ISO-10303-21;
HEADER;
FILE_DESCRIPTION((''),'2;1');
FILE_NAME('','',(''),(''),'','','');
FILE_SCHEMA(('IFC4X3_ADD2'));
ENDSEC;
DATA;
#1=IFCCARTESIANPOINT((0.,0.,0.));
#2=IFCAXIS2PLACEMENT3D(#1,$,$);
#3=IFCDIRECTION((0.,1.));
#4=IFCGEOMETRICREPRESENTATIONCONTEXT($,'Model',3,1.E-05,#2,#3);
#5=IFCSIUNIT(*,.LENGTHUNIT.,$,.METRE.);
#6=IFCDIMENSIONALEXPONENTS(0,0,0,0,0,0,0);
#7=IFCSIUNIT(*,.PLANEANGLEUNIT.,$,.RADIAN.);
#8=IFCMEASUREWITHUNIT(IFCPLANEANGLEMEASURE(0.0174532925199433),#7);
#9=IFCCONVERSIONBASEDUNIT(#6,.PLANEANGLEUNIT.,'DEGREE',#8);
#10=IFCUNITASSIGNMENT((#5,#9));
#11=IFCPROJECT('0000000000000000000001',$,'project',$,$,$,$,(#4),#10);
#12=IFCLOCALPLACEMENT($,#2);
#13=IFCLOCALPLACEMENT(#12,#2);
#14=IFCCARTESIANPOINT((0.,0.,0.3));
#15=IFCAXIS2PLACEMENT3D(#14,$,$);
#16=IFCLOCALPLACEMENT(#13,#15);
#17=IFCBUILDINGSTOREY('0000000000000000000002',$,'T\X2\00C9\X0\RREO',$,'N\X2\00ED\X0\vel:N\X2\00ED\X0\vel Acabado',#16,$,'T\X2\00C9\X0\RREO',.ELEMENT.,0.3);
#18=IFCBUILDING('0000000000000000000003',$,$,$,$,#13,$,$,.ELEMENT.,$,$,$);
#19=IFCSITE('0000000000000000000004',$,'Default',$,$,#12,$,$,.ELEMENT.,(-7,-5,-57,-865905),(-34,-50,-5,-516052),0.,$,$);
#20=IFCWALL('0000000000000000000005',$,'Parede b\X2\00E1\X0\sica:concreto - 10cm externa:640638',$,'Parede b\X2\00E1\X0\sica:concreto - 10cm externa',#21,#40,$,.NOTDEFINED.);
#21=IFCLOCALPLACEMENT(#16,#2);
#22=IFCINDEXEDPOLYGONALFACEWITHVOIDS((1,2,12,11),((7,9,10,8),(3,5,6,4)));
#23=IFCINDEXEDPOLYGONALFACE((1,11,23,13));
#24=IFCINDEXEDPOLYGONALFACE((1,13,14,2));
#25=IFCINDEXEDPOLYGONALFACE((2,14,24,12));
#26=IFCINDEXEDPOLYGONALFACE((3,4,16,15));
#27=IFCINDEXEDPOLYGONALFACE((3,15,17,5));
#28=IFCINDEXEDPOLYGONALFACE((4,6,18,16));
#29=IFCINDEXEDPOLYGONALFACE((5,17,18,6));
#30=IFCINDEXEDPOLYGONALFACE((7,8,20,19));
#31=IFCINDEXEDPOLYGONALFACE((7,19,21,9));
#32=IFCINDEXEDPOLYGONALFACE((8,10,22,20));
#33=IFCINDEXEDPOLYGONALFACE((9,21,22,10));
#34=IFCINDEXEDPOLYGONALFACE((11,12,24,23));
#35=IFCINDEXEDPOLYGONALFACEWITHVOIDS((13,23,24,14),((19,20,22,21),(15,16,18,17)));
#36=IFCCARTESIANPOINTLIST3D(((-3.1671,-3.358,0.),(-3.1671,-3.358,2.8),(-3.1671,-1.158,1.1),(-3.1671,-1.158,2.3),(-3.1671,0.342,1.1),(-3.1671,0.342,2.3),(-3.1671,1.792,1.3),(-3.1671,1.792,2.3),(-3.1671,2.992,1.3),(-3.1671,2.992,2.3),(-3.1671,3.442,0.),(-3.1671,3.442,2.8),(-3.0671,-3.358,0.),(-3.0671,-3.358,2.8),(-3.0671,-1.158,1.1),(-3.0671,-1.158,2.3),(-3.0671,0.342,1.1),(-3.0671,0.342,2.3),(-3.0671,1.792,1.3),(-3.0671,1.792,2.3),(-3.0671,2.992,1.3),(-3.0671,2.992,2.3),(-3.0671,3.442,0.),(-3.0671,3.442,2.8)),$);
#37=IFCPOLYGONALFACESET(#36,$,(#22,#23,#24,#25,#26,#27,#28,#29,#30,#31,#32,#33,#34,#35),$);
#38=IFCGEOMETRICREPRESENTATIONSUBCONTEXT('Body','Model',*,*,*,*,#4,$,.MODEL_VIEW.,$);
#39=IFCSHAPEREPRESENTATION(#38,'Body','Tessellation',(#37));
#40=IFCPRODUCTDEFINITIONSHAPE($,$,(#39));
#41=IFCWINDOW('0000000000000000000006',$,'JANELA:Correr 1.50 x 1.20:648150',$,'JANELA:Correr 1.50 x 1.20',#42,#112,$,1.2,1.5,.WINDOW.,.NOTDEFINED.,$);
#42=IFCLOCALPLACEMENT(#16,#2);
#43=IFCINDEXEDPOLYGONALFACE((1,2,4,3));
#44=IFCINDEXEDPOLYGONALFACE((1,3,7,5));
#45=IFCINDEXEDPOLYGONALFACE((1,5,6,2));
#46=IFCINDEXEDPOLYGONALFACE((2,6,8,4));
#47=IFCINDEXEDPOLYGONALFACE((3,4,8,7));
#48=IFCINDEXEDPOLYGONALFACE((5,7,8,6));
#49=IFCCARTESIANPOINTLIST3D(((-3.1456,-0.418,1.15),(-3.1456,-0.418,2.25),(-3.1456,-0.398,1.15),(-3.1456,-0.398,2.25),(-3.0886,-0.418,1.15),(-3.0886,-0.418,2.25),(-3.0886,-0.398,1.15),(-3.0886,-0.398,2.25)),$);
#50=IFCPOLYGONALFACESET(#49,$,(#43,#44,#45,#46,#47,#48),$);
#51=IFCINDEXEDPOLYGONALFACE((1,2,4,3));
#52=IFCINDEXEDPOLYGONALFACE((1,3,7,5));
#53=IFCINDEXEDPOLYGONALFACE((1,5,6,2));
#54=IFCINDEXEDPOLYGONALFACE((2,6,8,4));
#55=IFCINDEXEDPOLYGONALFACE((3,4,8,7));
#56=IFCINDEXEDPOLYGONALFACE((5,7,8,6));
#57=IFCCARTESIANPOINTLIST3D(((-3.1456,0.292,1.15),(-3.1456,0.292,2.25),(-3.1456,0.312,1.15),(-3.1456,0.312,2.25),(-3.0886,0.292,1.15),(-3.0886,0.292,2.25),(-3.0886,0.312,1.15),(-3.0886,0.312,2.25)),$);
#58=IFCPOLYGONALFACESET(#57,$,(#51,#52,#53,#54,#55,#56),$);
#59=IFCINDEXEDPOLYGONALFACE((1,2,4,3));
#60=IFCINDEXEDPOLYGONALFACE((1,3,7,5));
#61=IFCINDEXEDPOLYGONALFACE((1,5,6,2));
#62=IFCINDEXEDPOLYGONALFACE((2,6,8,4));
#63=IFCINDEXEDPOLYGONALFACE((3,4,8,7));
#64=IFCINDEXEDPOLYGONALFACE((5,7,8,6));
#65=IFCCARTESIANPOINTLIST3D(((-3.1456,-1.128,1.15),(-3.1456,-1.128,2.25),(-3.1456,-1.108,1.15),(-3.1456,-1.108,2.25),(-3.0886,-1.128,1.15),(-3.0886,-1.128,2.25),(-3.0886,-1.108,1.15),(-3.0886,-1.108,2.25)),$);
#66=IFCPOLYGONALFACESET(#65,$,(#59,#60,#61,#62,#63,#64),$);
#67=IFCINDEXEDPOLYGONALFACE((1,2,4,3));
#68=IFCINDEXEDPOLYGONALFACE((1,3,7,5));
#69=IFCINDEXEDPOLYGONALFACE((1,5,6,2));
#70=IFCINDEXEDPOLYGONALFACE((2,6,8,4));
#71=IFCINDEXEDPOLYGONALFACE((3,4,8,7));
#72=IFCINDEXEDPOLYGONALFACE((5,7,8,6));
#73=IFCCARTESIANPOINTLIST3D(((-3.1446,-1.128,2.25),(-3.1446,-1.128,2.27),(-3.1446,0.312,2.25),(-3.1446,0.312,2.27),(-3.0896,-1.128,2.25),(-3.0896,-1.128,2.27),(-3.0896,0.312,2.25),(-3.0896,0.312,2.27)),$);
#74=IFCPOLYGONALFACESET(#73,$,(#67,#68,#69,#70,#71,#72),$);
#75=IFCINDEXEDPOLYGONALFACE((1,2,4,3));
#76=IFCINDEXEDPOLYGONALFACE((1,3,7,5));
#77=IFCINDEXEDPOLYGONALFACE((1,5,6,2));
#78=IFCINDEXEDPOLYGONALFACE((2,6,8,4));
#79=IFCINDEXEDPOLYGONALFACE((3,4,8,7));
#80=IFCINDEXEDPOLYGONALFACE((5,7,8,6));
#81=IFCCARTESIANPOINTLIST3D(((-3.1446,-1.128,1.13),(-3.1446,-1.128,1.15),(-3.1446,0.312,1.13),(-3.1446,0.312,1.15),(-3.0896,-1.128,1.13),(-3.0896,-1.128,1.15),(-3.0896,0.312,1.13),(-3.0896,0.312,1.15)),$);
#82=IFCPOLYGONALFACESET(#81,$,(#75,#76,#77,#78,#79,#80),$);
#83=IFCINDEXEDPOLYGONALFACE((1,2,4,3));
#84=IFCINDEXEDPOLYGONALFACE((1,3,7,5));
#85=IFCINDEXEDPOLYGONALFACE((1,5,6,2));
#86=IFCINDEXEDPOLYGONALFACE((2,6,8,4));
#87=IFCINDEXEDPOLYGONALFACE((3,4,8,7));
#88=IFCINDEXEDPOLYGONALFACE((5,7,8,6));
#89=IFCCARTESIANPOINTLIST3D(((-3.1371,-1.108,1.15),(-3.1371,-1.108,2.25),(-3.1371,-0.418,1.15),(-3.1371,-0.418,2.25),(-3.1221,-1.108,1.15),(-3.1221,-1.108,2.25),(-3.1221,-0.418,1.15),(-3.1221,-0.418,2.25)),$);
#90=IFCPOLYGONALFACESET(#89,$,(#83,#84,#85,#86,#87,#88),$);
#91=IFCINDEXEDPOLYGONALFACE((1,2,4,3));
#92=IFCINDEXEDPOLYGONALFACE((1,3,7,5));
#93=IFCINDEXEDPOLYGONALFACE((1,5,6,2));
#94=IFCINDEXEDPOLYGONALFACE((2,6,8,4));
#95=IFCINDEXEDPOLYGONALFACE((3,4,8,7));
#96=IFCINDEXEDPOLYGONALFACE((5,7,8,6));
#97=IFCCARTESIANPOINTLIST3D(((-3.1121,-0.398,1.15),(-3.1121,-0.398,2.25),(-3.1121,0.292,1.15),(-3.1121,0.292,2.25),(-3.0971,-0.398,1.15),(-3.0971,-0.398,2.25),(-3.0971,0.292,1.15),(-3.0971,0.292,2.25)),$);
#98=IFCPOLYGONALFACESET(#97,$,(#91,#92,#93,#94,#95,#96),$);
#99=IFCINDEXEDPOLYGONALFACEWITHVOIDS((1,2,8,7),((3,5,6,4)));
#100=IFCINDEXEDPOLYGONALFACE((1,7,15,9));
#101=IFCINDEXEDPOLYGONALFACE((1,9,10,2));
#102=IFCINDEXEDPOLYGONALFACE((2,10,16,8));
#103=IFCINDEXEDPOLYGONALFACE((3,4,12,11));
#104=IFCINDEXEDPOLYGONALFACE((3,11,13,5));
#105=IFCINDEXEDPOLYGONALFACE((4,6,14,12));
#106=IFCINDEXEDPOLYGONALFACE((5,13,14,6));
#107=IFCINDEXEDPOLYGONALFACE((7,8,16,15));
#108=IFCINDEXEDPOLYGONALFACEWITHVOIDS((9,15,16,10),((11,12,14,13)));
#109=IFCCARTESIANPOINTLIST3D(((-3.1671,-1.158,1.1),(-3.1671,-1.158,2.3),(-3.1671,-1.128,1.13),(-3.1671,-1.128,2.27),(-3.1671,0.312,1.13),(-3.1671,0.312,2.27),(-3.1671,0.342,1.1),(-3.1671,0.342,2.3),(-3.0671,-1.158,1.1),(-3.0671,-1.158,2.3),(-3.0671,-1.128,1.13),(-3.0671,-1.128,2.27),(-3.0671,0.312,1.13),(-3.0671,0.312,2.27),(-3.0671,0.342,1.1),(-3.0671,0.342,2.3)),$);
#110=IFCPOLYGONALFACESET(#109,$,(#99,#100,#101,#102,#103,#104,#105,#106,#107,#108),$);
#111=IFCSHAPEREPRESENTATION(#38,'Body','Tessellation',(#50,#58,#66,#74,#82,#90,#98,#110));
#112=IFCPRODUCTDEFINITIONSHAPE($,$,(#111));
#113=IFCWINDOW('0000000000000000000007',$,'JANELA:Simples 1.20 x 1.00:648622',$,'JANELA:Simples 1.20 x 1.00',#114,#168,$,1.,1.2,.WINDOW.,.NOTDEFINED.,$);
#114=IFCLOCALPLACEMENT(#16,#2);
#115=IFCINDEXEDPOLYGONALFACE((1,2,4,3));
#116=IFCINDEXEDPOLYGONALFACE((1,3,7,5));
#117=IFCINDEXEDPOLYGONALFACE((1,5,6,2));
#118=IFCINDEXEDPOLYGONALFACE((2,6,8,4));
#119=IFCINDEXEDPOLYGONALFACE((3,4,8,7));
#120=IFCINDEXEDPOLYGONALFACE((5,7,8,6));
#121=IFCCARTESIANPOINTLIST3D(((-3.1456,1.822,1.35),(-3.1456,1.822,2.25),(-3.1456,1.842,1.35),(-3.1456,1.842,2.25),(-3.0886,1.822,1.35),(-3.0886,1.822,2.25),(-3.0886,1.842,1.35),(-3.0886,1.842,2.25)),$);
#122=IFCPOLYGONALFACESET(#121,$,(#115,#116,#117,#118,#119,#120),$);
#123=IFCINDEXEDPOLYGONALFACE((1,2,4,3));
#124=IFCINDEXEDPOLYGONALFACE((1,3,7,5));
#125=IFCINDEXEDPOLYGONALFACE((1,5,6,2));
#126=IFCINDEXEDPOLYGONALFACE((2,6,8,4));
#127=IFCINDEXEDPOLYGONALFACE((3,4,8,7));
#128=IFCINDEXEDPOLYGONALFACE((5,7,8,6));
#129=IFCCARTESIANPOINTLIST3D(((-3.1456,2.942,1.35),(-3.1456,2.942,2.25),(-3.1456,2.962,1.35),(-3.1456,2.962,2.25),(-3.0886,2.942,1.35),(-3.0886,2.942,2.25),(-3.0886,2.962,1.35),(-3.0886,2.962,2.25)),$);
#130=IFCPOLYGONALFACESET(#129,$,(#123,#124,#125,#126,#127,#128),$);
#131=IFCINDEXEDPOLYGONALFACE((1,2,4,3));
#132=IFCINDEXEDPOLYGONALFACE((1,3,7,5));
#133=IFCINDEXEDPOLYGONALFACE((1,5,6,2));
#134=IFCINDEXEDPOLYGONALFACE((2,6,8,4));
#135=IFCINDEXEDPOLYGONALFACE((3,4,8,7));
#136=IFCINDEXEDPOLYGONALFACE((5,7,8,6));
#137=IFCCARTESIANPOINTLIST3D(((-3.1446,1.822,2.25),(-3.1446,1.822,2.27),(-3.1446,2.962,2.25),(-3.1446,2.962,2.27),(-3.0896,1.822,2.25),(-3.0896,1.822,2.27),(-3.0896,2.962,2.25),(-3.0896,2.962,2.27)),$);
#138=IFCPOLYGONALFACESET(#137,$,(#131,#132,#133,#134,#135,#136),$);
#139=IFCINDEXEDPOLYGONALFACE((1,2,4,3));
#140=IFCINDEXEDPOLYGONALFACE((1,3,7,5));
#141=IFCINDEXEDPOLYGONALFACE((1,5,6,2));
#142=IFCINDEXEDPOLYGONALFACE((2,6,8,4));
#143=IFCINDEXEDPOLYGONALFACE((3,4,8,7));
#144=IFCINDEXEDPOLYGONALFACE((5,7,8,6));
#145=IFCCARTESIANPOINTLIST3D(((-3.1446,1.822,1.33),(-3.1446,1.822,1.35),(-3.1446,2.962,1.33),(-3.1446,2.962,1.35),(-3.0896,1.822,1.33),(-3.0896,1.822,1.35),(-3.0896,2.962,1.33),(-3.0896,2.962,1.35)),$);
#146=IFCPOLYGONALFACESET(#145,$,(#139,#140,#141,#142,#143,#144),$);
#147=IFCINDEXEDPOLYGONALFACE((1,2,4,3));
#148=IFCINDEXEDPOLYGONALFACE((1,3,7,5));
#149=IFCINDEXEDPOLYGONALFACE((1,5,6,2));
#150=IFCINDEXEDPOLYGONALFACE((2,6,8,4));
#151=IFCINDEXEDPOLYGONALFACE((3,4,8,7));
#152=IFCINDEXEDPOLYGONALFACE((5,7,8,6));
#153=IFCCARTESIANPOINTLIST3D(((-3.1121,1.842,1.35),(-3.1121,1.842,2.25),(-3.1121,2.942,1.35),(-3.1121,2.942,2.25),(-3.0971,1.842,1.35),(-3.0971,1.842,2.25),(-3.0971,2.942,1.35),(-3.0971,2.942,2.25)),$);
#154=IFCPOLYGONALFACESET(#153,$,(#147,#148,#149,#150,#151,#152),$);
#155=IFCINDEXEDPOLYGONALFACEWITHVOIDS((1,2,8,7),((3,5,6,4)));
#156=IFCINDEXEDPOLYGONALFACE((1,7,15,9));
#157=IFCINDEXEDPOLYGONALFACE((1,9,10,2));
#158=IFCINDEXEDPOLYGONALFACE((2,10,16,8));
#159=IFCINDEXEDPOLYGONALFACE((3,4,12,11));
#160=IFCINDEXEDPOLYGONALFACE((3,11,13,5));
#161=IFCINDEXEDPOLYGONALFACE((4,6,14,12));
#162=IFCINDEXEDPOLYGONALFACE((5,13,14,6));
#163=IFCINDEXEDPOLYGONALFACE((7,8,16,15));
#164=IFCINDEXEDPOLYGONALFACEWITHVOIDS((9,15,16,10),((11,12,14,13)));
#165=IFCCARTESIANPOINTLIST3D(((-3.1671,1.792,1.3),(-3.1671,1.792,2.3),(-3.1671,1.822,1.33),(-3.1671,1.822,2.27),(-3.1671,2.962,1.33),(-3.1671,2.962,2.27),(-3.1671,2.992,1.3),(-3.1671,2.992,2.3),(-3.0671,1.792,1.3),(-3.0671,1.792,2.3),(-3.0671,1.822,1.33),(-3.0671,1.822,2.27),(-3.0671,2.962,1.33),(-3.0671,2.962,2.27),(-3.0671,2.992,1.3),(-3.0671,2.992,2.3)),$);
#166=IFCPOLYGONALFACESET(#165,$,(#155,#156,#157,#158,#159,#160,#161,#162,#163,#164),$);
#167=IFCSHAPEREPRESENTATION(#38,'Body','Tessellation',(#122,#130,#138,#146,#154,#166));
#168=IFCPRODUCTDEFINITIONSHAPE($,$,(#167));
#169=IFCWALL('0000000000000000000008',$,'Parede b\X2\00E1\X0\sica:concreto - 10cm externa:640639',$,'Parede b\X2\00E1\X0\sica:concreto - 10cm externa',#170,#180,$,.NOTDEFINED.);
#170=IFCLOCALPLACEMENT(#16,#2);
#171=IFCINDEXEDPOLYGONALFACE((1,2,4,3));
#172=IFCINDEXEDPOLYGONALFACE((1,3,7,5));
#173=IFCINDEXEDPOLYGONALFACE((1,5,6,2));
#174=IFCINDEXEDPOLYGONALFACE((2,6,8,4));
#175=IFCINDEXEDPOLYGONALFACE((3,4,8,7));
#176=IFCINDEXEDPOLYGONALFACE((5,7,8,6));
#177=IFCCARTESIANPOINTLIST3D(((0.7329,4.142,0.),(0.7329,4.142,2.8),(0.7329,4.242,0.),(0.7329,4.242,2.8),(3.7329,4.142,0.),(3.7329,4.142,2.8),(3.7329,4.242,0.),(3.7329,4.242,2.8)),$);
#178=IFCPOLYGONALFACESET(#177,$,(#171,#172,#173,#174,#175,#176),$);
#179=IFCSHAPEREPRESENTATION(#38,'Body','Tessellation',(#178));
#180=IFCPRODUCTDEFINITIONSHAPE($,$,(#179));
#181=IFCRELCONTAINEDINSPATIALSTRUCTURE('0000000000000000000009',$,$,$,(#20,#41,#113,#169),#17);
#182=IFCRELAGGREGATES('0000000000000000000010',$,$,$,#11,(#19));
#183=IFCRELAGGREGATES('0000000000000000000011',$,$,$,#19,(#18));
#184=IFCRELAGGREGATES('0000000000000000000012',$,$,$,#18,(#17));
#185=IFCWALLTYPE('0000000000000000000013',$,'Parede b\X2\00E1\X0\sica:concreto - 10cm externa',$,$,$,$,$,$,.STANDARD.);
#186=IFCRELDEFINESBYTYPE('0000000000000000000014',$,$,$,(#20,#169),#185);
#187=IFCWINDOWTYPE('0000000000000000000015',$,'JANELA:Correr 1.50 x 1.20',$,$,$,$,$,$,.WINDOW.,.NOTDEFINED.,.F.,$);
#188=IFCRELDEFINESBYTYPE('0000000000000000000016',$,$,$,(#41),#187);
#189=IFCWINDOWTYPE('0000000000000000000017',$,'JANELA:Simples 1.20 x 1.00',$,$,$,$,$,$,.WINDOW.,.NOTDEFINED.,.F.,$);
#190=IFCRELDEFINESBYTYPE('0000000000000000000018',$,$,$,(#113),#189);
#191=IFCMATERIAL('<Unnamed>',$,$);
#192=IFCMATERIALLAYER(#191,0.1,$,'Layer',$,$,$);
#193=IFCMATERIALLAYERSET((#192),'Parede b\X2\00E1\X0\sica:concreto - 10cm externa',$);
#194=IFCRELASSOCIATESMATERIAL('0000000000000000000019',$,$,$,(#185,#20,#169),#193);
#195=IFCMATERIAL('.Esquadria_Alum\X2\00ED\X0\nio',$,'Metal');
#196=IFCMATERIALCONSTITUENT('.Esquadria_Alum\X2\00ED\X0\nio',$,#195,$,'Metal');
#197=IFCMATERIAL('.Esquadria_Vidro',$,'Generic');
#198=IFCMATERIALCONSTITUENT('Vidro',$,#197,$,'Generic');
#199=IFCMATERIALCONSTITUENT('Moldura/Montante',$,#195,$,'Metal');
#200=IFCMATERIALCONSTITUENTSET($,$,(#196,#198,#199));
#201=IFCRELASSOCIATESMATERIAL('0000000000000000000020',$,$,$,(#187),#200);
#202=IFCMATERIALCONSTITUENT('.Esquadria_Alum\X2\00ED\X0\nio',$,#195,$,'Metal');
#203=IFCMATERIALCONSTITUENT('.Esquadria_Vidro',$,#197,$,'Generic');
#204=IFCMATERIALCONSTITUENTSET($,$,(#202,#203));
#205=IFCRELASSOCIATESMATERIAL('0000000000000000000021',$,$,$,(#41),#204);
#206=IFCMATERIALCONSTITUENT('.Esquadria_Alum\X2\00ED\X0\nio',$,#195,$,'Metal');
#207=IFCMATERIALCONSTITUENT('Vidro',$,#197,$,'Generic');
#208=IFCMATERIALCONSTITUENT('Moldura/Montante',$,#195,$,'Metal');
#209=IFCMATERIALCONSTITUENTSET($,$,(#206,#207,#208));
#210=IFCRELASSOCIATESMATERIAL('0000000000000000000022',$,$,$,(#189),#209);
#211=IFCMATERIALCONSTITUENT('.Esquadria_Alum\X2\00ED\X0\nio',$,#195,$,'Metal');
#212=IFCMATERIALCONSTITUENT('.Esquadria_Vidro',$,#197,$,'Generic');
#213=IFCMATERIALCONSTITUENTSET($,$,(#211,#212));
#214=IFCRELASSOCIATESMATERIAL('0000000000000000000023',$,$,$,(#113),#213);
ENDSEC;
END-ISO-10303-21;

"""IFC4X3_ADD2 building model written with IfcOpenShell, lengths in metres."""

from ifc_helpers import new_model, entity, si_unit, converted_unit, direction, frame, frame_2d, origin, origin_2d_with_axis, place, context, subcontext, project, spatial, polyline, rectangle, outline, extrude, source, transform, mapped, material, layer, layer_set, constituent, constituent_set, type_object, type_shapes, element, fill, save


model = new_model("IFC4X3_ADD2")

# Units and contexts
model_context = context("Model", 3, precision=1e-05, world=origin(), true_north=direction((0.0, 1.0)))
body_context = subcontext(model_context, "Body", "Model", "MODEL_VIEW")
ifc_project = project(units=[si_unit("LENGTHUNIT", "METRE"), converted_unit("PLANEANGLEUNIT", "DEGREE", entity("IfcPlaneAngleMeasure", 0.0174532925199433), si_unit("PLANEANGLEUNIT", "RADIAN"), dimensions=[0, 0, 0, 0, 0, 0, 0])], contexts=[model_context])

# Site, building, storey
site_placement = place(None, origin())
site = spatial("IfcSite", under=ifc_project, at=site_placement, Name="Default", CompositionType="ELEMENT", RefLatitude=(-7, -5, -57, -865905), RefLongitude=(-34, -50, -5, -516052), RefElevation=0.0)
building_placement = place(site_placement, origin())
building = spatial("IfcBuilding", under=site, at=building_placement, CompositionType="ELEMENT")
storey_placement = place(building_placement, frame((0.0, 0.0, 0.3)))
storey = spatial("IfcBuildingStorey", under=building, at=storey_placement, Name="TÉRREO", ObjectType="Nível:Nível Acabado", LongName="TÉRREO", CompositionType="ELEMENT", Elevation=0.3)

# Shared definitions
ifc_material_1 = material(Name="<Unnamed>")
ifc_layer_1 = layer(ifc_material_1, 0.1, Name="Layer")
ifc_layer_set_1 = layer_set([ifc_layer_1], Name="Parede básica:concreto - 10cm externa")
wall_type_1 = type_object("IfcWallType", Name="Parede básica:concreto - 10cm externa", PredefinedType="STANDARD", material=ifc_layer_set_1)
ifc_material_2 = material(Name=".Esquadria_Alumínio", Category="Metal")
ifc_material_3 = material(Name=".Esquadria_Vidro", Category="Generic")
ifc_constituent_1 = constituent(ifc_material_2, Name=".Esquadria_Alumínio", Category="Metal")
ifc_constituent_2 = constituent(ifc_material_3, Name="Vidro", Category="Generic")
ifc_constituent_3 = constituent(ifc_material_2, Name="Moldura/Montante", Category="Metal")
ifc_constituent_set_1 = constituent_set(constituents=[ifc_constituent_1, ifc_constituent_2, ifc_constituent_3])
window_type_1 = type_object("IfcWindowType", Name="JANELA:Correr 1.50 x 1.20", ParameterTakesPrecedence=False, PartitioningType="NOTDEFINED", PredefinedType="WINDOW", material=ifc_constituent_set_1)
shared_shape_1 = source(origin(), body_context, "Body", "SweptSolid", [
    extrude(rectangle(XDim=0.02, YDim=0.057, at=origin_2d_with_axis()), frame((0.75, 0.05, 0.05), z_axis=(0.0, 0.0, 1.0), x_axis=(-1.0, 0.0, 0.0)), (0.0, 0.0, 1.0), 1.1),
    extrude(rectangle(XDim=0.02, YDim=0.057, at=origin_2d_with_axis()), frame((0.04, 0.05, 0.05), z_axis=(0.0, 0.0, 1.0), x_axis=(-1.0, 0.0, 0.0)), (0.0, 0.0, 1.0), 1.1),
    extrude(rectangle(XDim=0.02, YDim=0.057, at=origin_2d_with_axis()), frame((1.46, 0.05, 0.05), z_axis=(0.0, 0.0, 1.0), x_axis=(-1.0, 0.0, 0.0)), (0.0, 0.0, 1.0), 1.1),
    extrude(rectangle(XDim=1.44, YDim=0.055, at=origin_2d_with_axis()), frame((0.75, 0.05, 1.15), z_axis=(0.0, 0.0, 1.0), x_axis=(-1.0, 0.0, 0.0)), (0.0, 0.0, 1.0), 0.02),
    extrude(rectangle(XDim=1.44, YDim=0.055, at=origin_2d_with_axis()), frame((0.75, 0.05, 0.03), z_axis=(0.0, 0.0, 1.0), x_axis=(-1.0, 0.0, 0.0)), (0.0, 0.0, 1.0), 0.02),
    extrude(rectangle(XDim=0.015, YDim=0.69, at=frame_2d((0.0, 0.0), x_axis=(1.0, 0.0))), frame((1.105, 0.0375, 0.05), z_axis=(0.0, 0.0, 1.0), x_axis=(0.0, 1.0, 0.0)), (0.0, 0.0, 1.0), 1.1),
    extrude(rectangle(XDim=0.015, YDim=0.69, at=origin_2d_with_axis()), frame((0.395, 0.0625, 0.05), z_axis=(0.0, 0.0, 1.0), x_axis=(0.0, 1.0, 0.0)), (0.0, 0.0, 1.0), 1.1),
    extrude(outline(polyline([(-0.75, -0.6), (0.75, -0.6), (0.75, 0.6), (-0.75, 0.6), (-0.75, -0.6)]), holes=[polyline([(0.72, -0.57), (-0.72, -0.57), (-0.72, 0.57), (0.72, 0.57), (0.72, -0.57)])]), frame((0.75, 0.0, 0.6), z_axis=(0.0, 1.0, 0.0), x_axis=(1.0, 0.0, 0.0)), (0.0, 0.0, 1.0), 0.1),
])
type_shapes(window_type_1, [shared_shape_1])

# Wall, openings, windows
wall_1_placement = place(storey_placement, frame((-3.1171, -3.358, 0.0), z_axis=(0.0, 0.0, 1.0), x_axis=(0.0, 1.0, 0.0)))
wall_1 = element("IfcWall", 1, at=wall_1_placement, inside=storey, type_object=wall_type_1, material=ifc_layer_set_1, Name="Parede básica:concreto - 10cm externa:640638", ObjectType="Parede básica:concreto - 10cm externa", PredefinedType="NOTDEFINED", context=body_context, shape_type="SweptSolid", body=[
    extrude(rectangle(XDim=6.8, YDim=0.1, at=frame_2d((3.4, 0.0), x_axis=(-1.0, 0.0))), origin(), (0.0, 0.0, 1.0), 2.8),
])
opening_1_placement = place(wall_1_placement, frame((3.7, 0.05, 1.1)))
opening_1 = element("IfcOpeningElement", 2, at=opening_1_placement, cuts=wall_1, PredefinedType="OPENING", context=body_context, shape_type="SweptSolid", body=[
    extrude(rectangle(XDim=1.2, YDim=1.5, at=frame_2d((0.6, 0.75), x_axis=(1.0, 0.0))), frame((0.0, 0.0, 0.0), z_axis=(0.0, -1.0, 0.0), x_axis=(0.0, 0.0, 1.0)), (0.0, 0.0, 1.0), 0.1),
])
opening_2_placement = place(wall_1_placement, frame((5.15, -0.05, 1.3)))
opening_2 = element("IfcOpeningElement", 3, at=opening_2_placement, cuts=wall_1, PredefinedType="OPENING", context=body_context, shape_type="SweptSolid", body=[
    extrude(rectangle(XDim=1.0, YDim=1.2, at=frame_2d((0.5, 0.6), x_axis=(1.0, 0.0))), frame((0.0, 0.0, 0.0), z_axis=(0.0, 1.0, 0.0), x_axis=(0.0, 0.0, 1.0)), (0.0, 0.0, 1.0), 0.1),
])
ifc_constituent_4 = constituent(ifc_material_2, Name=".Esquadria_Alumínio", Category="Metal")
ifc_constituent_5 = constituent(ifc_material_3, Name=".Esquadria_Vidro", Category="Generic")
ifc_constituent_set_2 = constituent_set(constituents=[ifc_constituent_4, ifc_constituent_5])
window_1_placement = place(opening_1_placement, frame((0.0, 0.0, 0.0), z_axis=(0.0, 0.0, 1.0), x_axis=(-1.0, 0.0, 0.0)))
window_1 = element("IfcWindow", 4, at=window_1_placement, inside=storey, type_object=window_type_1, material=ifc_constituent_set_2, Name="JANELA:Correr 1.50 x 1.20:648150", ObjectType="JANELA:Correr 1.50 x 1.20", OverallHeight=1.2, OverallWidth=1.5, PartitioningType="NOTDEFINED", PredefinedType="WINDOW", context=body_context, shape_type="MappedRepresentation", body=[
    mapped(shared_shape_1, transform((0.0, 0.0, 0.0), scale=1.0)),
])
fill(opening_1, window_1)
ifc_constituent_6 = constituent(ifc_material_2, Name=".Esquadria_Alumínio", Category="Metal")
ifc_constituent_7 = constituent(ifc_material_3, Name=".Esquadria_Vidro", Category="Generic")
ifc_constituent_set_3 = constituent_set(constituents=[ifc_constituent_6, ifc_constituent_7])
ifc_constituent_8 = constituent(ifc_material_2, Name=".Esquadria_Alumínio", Category="Metal")
ifc_constituent_9 = constituent(ifc_material_3, Name="Vidro", Category="Generic")
ifc_constituent_10 = constituent(ifc_material_2, Name="Moldura/Montante", Category="Metal")
ifc_constituent_set_4 = constituent_set(constituents=[ifc_constituent_8, ifc_constituent_9, ifc_constituent_10])
window_type_2 = type_object("IfcWindowType", Name="JANELA:Simples 1.20 x 1.00", ParameterTakesPrecedence=False, PartitioningType="NOTDEFINED", PredefinedType="WINDOW", material=ifc_constituent_set_4)
shared_shape_2 = source(origin(), body_context, "Body", "SweptSolid", [
    extrude(rectangle(XDim=0.02, YDim=0.057, at=frame_2d((0.0, 0.0), x_axis=(1.0, 0.0))), frame((0.04, 0.05, 0.05), z_axis=(0.0, 0.0, 1.0), x_axis=(-1.0, 0.0, 0.0)), (0.0, 0.0, 1.0), 0.9),
    extrude(rectangle(XDim=0.02, YDim=0.057, at=frame_2d((0.0, 0.0), x_axis=(1.0, 0.0))), frame((1.16, 0.05, 0.05), z_axis=(0.0, 0.0, 1.0), x_axis=(-1.0, 0.0, 0.0)), (0.0, 0.0, 1.0), 0.9),
    extrude(rectangle(XDim=1.14, YDim=0.055, at=frame_2d((0.0, 0.0), x_axis=(1.0, 0.0))), frame((0.6, 0.05, 0.95), z_axis=(0.0, 0.0, 1.0), x_axis=(-1.0, 0.0, 0.0)), (0.0, 0.0, 1.0), 0.02),
    extrude(rectangle(XDim=1.14, YDim=0.055, at=frame_2d((0.0, 0.0), x_axis=(1.0, 0.0))), frame((0.6, 0.05, 0.03), z_axis=(0.0, 0.0, 1.0), x_axis=(-1.0, 0.0, 0.0)), (0.0, 0.0, 1.0), 0.02),
    extrude(rectangle(XDim=0.015, YDim=1.1, at=frame_2d((0.0, 0.0), x_axis=(1.0, 0.0))), frame((0.6, 0.0375, 0.05), z_axis=(0.0, 0.0, 1.0), x_axis=(0.0, 1.0, 0.0)), (0.0, 0.0, 1.0), 0.9),
    extrude(outline(polyline([(-0.6, -0.5), (0.6, -0.5), (0.6, 0.5), (-0.6, 0.5), (-0.6, -0.5)]), holes=[polyline([(0.57, -0.47), (-0.57, -0.47), (-0.57, 0.47), (0.57, 0.47), (0.57, -0.47)])]), frame((0.6, 0.0, 0.5), z_axis=(0.0, 1.0, 0.0), x_axis=(1.0, 0.0, 0.0)), (0.0, 0.0, 1.0), 0.1),
])
type_shapes(window_type_2, [shared_shape_2])
window_2_placement = place(opening_2_placement, origin())
window_2 = element("IfcWindow", 5, at=window_2_placement, inside=storey, type_object=window_type_2, material=ifc_constituent_set_3, Name="JANELA:Simples 1.20 x 1.00:648622", ObjectType="JANELA:Simples 1.20 x 1.00", OverallHeight=1.0, OverallWidth=1.2, PartitioningType="NOTDEFINED", PredefinedType="WINDOW", context=body_context, shape_type="MappedRepresentation", body=[
    mapped(shared_shape_2, transform((0.0, 0.0, 0.0), scale=1.0)),
])
fill(opening_2, window_2)

# Wall
wall_2_placement = place(storey_placement, frame((0.7329, 4.192, 0.0)))
element("IfcWall", 6, at=wall_2_placement, inside=storey, type_object=wall_type_1, material=ifc_layer_set_1, Name="Parede básica:concreto - 10cm externa:640639", ObjectType="Parede básica:concreto - 10cm externa", PredefinedType="NOTDEFINED", context=body_context, shape_type="SweptSolid", body=[
    extrude(rectangle(XDim=3.0, YDim=0.1, at=frame_2d((1.5, 0.0), x_axis=(-1.0, 0.0))), origin(), (0.0, 0.0, 1.0), 2.8),
])

save(model, "model.ifc")
